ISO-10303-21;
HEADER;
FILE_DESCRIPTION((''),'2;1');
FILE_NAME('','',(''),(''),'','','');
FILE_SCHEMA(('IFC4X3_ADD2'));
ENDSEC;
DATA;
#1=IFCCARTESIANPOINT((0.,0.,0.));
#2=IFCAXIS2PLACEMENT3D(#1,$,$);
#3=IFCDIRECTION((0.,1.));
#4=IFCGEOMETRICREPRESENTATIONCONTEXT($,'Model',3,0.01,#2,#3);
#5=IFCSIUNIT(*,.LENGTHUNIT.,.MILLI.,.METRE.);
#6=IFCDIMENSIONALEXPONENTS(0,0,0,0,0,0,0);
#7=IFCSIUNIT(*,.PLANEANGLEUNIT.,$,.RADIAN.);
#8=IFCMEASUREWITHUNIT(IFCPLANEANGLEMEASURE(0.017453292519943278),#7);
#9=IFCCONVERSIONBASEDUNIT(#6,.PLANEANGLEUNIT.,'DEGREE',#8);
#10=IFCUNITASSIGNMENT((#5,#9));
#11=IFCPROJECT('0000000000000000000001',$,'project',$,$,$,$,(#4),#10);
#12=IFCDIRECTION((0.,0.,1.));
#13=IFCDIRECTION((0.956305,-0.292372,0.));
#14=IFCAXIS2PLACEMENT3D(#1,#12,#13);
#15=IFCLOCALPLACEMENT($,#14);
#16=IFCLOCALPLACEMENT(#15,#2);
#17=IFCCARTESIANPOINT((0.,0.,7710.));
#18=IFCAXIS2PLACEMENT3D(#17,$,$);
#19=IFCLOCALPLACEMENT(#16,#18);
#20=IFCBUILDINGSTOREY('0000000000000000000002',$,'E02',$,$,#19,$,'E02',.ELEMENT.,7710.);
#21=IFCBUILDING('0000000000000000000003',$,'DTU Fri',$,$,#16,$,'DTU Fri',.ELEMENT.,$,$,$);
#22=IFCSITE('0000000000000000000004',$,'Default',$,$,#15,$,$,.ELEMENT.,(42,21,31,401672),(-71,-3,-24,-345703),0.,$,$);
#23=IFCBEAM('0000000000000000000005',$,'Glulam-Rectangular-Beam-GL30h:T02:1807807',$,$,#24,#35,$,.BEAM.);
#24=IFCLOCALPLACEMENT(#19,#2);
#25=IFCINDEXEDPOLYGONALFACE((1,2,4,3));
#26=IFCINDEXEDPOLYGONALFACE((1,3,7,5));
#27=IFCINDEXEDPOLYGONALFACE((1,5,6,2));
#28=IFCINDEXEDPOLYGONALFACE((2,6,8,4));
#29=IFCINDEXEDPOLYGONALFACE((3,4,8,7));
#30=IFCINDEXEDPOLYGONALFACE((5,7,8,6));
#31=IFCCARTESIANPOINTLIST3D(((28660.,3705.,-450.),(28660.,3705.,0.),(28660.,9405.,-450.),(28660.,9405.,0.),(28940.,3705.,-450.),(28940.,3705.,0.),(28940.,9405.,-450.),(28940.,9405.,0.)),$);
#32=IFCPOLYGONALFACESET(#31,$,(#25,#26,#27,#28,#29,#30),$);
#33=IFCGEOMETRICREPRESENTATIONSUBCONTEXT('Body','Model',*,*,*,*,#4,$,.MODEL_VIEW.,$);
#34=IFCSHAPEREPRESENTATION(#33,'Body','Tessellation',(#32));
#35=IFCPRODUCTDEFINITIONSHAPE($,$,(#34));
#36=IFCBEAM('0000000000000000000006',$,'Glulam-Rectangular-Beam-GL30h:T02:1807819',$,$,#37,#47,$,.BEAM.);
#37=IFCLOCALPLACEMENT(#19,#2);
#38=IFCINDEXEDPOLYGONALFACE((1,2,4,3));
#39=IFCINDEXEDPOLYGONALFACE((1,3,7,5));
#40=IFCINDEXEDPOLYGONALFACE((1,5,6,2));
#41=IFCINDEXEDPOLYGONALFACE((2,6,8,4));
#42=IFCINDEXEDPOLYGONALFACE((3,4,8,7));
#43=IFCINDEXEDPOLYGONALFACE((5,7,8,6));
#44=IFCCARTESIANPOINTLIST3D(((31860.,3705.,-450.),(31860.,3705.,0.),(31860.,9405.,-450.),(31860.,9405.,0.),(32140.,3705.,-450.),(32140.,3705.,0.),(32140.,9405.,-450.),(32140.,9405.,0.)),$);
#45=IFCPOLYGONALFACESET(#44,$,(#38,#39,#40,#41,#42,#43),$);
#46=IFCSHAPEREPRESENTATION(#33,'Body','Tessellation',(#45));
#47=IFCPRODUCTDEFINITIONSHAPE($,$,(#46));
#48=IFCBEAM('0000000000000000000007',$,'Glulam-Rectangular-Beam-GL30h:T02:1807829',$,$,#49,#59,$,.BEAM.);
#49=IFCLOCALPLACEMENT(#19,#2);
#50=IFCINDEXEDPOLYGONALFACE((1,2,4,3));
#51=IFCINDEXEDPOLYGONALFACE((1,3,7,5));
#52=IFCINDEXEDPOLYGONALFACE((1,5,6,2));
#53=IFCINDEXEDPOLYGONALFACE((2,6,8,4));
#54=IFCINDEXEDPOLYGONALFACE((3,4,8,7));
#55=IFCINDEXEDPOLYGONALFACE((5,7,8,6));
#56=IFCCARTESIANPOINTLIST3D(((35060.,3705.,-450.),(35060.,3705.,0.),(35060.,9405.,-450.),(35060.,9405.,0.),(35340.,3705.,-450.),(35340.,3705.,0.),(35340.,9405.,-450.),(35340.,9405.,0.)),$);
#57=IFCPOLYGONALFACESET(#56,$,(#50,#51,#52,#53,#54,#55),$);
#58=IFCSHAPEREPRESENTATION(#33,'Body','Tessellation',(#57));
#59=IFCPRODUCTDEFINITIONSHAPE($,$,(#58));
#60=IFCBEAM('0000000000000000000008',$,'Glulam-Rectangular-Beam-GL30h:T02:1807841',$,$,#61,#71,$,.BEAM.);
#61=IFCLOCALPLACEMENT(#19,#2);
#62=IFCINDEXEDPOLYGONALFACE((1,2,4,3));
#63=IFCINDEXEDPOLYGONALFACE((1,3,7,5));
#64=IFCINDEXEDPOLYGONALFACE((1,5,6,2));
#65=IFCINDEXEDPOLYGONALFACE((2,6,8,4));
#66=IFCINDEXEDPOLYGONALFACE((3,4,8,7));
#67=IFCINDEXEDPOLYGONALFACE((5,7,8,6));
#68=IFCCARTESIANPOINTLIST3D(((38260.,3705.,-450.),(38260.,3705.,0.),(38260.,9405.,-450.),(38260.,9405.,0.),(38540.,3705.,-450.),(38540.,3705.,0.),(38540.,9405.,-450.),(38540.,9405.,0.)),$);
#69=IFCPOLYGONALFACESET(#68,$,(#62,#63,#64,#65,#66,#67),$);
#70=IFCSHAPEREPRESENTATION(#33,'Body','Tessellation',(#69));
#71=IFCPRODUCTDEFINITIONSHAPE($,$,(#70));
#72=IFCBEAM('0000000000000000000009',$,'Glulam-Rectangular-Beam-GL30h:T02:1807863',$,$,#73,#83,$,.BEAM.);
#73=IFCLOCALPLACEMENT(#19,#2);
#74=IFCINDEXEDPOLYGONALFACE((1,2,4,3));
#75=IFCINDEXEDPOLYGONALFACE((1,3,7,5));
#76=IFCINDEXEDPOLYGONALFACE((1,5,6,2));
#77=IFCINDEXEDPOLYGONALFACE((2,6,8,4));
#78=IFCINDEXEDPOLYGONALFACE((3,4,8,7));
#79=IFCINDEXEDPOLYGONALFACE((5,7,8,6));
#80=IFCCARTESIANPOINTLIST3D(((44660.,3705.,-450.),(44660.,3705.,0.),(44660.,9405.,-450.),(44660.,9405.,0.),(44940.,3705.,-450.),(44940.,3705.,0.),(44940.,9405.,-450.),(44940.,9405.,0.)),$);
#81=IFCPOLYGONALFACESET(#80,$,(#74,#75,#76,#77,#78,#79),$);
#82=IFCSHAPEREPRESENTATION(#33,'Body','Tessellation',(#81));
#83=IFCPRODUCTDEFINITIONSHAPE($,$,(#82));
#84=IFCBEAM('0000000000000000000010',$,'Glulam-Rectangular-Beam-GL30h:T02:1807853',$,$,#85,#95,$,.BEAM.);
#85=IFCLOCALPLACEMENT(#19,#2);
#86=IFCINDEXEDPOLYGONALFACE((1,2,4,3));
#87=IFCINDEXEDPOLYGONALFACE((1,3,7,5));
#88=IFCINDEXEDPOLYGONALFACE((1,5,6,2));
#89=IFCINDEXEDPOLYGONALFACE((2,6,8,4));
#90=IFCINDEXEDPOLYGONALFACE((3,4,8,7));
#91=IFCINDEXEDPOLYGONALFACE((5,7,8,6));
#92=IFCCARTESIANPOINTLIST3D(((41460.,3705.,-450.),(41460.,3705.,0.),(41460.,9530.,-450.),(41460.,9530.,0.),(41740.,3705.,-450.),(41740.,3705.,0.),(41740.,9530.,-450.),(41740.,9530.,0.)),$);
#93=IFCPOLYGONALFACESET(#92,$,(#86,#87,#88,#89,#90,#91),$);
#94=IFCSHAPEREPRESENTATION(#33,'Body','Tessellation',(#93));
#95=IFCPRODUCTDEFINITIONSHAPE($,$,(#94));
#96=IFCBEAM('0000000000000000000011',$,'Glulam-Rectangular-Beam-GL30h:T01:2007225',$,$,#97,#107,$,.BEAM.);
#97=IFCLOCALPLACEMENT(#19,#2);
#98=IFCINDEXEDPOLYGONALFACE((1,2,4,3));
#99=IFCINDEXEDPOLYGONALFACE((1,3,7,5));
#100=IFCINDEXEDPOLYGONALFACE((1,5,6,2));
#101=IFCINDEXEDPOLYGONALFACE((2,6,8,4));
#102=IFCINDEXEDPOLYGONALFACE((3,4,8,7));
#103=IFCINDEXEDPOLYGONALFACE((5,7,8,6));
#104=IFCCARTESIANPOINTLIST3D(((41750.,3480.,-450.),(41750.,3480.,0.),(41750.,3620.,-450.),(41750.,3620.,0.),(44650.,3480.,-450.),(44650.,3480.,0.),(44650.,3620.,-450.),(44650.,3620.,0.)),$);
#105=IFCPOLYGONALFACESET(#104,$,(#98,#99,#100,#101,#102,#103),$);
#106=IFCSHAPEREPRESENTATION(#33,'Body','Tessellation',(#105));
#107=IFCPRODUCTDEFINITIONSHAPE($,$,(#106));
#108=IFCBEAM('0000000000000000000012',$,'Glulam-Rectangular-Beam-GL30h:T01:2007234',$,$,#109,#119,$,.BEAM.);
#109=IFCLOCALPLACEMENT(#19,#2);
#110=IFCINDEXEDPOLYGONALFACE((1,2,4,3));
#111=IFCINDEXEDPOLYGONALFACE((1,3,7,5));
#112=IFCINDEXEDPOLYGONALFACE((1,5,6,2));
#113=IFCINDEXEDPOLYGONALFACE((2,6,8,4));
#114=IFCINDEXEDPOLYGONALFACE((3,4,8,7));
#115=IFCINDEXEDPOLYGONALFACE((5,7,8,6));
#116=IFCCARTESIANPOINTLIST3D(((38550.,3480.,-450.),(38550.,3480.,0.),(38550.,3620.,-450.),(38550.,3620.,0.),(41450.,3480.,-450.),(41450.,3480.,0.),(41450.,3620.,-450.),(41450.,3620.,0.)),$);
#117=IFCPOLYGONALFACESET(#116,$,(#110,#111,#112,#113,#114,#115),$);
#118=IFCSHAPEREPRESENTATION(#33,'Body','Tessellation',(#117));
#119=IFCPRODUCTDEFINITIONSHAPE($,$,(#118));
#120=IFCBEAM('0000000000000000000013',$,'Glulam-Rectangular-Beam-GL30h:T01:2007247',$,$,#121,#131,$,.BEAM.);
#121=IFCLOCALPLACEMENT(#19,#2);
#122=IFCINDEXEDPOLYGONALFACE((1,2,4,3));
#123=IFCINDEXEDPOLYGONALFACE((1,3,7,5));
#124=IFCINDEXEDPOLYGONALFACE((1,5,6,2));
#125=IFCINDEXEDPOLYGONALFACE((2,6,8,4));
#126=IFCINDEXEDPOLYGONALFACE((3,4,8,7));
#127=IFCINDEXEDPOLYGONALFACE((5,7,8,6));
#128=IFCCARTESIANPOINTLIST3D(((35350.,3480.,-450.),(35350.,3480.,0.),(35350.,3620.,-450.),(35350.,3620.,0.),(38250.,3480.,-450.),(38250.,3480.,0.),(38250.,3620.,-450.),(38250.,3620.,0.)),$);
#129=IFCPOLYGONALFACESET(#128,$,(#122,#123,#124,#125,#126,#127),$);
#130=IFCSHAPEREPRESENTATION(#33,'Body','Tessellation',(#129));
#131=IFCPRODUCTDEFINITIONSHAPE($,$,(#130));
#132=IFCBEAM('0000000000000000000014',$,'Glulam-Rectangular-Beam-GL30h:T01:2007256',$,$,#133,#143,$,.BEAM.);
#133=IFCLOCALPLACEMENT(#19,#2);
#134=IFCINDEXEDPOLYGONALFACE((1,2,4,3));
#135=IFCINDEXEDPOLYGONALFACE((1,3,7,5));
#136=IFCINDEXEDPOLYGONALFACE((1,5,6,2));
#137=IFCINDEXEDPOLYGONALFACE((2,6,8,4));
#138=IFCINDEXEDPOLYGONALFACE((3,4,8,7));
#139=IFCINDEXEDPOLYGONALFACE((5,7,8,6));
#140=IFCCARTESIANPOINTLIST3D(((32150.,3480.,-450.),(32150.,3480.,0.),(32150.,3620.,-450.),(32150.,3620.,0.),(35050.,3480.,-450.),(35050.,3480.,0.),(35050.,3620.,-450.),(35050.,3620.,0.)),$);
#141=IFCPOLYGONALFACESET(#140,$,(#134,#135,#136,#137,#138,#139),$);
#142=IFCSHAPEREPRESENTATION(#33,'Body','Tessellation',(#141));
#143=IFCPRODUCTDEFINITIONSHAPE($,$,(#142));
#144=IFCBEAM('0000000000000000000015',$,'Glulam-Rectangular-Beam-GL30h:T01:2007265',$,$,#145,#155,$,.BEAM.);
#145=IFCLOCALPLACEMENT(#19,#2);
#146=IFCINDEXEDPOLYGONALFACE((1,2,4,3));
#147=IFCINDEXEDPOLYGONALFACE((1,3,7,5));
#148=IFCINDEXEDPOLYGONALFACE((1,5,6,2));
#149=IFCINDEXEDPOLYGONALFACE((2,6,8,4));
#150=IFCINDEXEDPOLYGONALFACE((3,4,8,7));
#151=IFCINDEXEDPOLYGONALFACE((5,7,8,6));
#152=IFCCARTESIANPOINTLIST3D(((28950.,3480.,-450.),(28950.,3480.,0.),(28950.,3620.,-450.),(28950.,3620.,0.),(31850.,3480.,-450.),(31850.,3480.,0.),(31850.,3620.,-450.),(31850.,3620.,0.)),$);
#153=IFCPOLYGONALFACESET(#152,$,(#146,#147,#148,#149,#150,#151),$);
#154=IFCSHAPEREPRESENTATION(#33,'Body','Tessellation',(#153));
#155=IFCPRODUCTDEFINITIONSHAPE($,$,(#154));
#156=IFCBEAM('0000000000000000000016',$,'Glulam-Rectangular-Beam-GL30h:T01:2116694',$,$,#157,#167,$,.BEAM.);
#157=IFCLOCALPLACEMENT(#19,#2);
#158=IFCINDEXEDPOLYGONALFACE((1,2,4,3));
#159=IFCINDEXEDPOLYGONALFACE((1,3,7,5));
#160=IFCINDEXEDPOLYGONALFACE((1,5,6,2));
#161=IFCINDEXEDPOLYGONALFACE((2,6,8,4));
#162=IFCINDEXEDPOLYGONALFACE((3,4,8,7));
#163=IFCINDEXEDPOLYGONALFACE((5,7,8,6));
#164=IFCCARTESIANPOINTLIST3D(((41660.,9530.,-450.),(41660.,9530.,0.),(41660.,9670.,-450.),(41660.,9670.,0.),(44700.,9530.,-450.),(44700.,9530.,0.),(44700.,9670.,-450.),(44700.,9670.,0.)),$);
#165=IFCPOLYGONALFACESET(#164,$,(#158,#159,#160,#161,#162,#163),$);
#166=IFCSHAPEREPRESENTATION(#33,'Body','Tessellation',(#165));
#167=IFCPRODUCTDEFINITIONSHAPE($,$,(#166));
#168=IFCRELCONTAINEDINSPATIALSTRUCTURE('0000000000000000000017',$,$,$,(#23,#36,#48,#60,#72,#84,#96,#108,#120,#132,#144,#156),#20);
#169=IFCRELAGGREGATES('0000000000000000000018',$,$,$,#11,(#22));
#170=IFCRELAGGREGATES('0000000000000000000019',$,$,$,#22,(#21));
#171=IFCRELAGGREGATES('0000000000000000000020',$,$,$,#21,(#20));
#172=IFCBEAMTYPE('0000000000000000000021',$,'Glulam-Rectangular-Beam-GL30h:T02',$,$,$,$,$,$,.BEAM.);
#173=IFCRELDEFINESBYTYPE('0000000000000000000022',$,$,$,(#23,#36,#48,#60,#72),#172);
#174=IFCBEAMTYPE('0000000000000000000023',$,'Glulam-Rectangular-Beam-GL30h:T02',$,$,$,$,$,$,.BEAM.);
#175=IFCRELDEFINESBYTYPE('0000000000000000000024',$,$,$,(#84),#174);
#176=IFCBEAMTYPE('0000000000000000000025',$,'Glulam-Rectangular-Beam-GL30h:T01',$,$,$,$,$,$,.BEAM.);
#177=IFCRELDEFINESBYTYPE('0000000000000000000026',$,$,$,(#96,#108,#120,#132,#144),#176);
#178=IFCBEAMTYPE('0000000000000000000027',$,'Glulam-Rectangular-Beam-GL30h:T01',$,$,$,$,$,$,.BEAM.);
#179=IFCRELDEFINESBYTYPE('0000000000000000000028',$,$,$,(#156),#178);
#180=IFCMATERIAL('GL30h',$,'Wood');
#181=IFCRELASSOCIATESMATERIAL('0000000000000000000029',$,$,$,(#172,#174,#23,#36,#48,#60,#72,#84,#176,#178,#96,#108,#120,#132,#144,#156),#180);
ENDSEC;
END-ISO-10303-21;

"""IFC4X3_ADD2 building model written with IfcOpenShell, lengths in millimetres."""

from ifc_helpers import new_model, entity, si_unit, converted_unit, direction, frame, origin, origin_2d_with_axis, place, context, subcontext, project, spatial, rectangle, extrude, source, transform, mapped, material, material_profile, profile_set, profile_usage, type_object, type_shapes, element, save


model = new_model("IFC4X3_ADD2")

# Units and contexts
model_context = context("Model", 3, precision=0.01, world=origin(), true_north=direction((0.0, 1.0)))
body_context = subcontext(model_context, "Body", "Model", "MODEL_VIEW")
ifc_project = project(units=[si_unit("LENGTHUNIT", "METRE", prefix="MILLI"), converted_unit("PLANEANGLEUNIT", "DEGREE", entity("IfcPlaneAngleMeasure", 0.017453292519943278), si_unit("PLANEANGLEUNIT", "RADIAN"), dimensions=[0, 0, 0, 0, 0, 0, 0])], contexts=[model_context])

# Site, building, storey
site_placement = place(None, frame((0.0, 0.0, 0.0), z_axis=(0.0, 0.0, 1.0), x_axis=(0.956305, -0.292372, 0.0)))
site = spatial("IfcSite", under=ifc_project, at=site_placement, Name="Default", CompositionType="ELEMENT", RefLatitude=(42, 21, 31, 401672), RefLongitude=(-71, -3, -24, -345703), RefElevation=0.0)
building_placement = place(site_placement, origin())
building = spatial("IfcBuilding", under=site, at=building_placement, Name="DTU Fri", LongName="DTU Fri", CompositionType="ELEMENT")
storey_placement = place(building_placement, frame((0.0, 0.0, 7710.0)))
storey = spatial("IfcBuildingStorey", under=building, at=storey_placement, Name="E02", LongName="E02", CompositionType="ELEMENT", Elevation=7710.0)

# Shared definitions
ifc_material = material(Name="GL30h", Category="Wood")

# Beams
ifc_material_profile_1 = material_profile(ifc_material, rectangle(XDim=450.0, YDim=140.0, at=origin_2d_with_axis()), Name="T01")
ifc_profile_set_1 = profile_set([ifc_material_profile_1], Name="T01")
ifc_profile_usage_1 = profile_usage(ifc_profile_set_1, cardinal=8)
ifc_material_profile_2 = material_profile(ifc_material, rectangle(XDim=450.0, YDim=280.0, at=origin_2d_with_axis()), Name="T02")
ifc_profile_set_2 = profile_set([ifc_material_profile_2], Name="T02")
ifc_profile_usage_2 = profile_usage(ifc_profile_set_2, cardinal=8)
beam_type_1 = type_object("IfcBeamType", Name="Glulam-Rectangular-Beam-GL30h:T02", PredefinedType="BEAM", material=ifc_profile_set_2)
shared_shape_1 = source(origin(), body_context, "Body", "SweptSolid", [
    extrude(rectangle(XDim=450.0, YDim=280.0, at=origin_2d_with_axis()), frame((-2872.5, 0.0, 0.0), z_axis=(1.0, 0.0, 0.0), x_axis=(0.0, 0.0, -1.0)), (0.0, 0.0, 1.0), 5700.0),
])
type_shapes(beam_type_1, [shared_shape_1])
for number, where, z_axis, x_axis, name in (
    (1, (28800.0, 6577.5, -225.0), (0.0, 0.0, 1.0), (0.0, 1.0, 0.0), "Glulam-Rectangular-Beam-GL30h:T02:1807807"),
    (2, (32000.0, 6577.5, -225.0), (0.0, 0.0, 1.0), (0.0, 1.0, 0.0), "Glulam-Rectangular-Beam-GL30h:T02:1807819"),
    (3, (35200.0, 6577.5, -225.0), (0.0, 0.0, 1.0), (0.0, 1.0, 0.0), "Glulam-Rectangular-Beam-GL30h:T02:1807829"),
    (4, (38400.0, 6577.5, -225.0), (0.0, 0.0, 1.0), (0.0, 1.0, 0.0), "Glulam-Rectangular-Beam-GL30h:T02:1807841"),
    (5, (44800.0, 6577.5, -225.0), (0.0, 0.0, 1.0), (0.0, 1.0, 0.0), "Glulam-Rectangular-Beam-GL30h:T02:1807863"),
):
    element("IfcBeam", number, at=place(storey_placement, frame(where, z_axis=z_axis, x_axis=x_axis)), inside=storey, type_object=beam_type_1, material=ifc_profile_usage_2, Name=name, PredefinedType="BEAM", context=body_context, shape_type="MappedRepresentation", body=[
        mapped(shared_shape_1, transform((0.0, 0.0, 0.0), scale=1.0)),
    ])
beam_type_2 = type_object("IfcBeamType", Name="Glulam-Rectangular-Beam-GL30h:T02", PredefinedType="BEAM", material=ifc_profile_set_2)
shared_shape_2 = source(origin(), body_context, "Body", "SweptSolid", [
    extrude(rectangle(XDim=450.0, YDim=280.0, at=origin_2d_with_axis()), frame((-2872.5, 0.0, 0.0), z_axis=(1.0, 0.0, 0.0), x_axis=(0.0, 0.0, -1.0)), (0.0, 0.0, 1.0), 5825.0),
])
type_shapes(beam_type_2, [shared_shape_2])
beam_1_placement = place(storey_placement, frame((41600.0, 6577.5, -225.0), z_axis=(0.0, 0.0, 1.0), x_axis=(0.0, 1.0, 0.0)))
element("IfcBeam", 6, at=beam_1_placement, inside=storey, type_object=beam_type_2, material=ifc_profile_usage_2, Name="Glulam-Rectangular-Beam-GL30h:T02:1807853", PredefinedType="BEAM", context=body_context, shape_type="MappedRepresentation", body=[
    mapped(shared_shape_2, transform((0.0, 0.0, 0.0), scale=1.0)),
])
beam_type_3 = type_object("IfcBeamType", Name="Glulam-Rectangular-Beam-GL30h:T01", PredefinedType="BEAM", material=ifc_profile_set_1)
shared_shape_3 = source(origin(), body_context, "Body", "SweptSolid", [
    extrude(rectangle(XDim=450.0, YDim=140.0, at=origin_2d_with_axis()), frame((-1460.0, 0.0, 0.0), z_axis=(1.0, 0.0, 0.0), x_axis=(0.0, 0.0, -1.0)), (0.0, 0.0, 1.0), 2900.0),
])
type_shapes(beam_type_3, [shared_shape_3])
for number, where, name in (
    (7, (43210.0, 3550.0, -225.0), "Glulam-Rectangular-Beam-GL30h:T01:2007225"),
    (8, (40010.0, 3550.0, -225.0), "Glulam-Rectangular-Beam-GL30h:T01:2007234"),
    (9, (36810.0, 3550.0, -225.0), "Glulam-Rectangular-Beam-GL30h:T01:2007247"),
    (10, (33610.0, 3550.0, -225.0), "Glulam-Rectangular-Beam-GL30h:T01:2007256"),
    (11, (30410.0, 3550.0, -225.0), "Glulam-Rectangular-Beam-GL30h:T01:2007265"),
):
    element("IfcBeam", number, at=place(storey_placement, frame(where)), inside=storey, type_object=beam_type_3, material=ifc_profile_usage_1, Name=name, PredefinedType="BEAM", context=body_context, shape_type="MappedRepresentation", body=[
        mapped(shared_shape_3, transform((0.0, 0.0, 0.0), scale=1.0)),
    ])
beam_type_4 = type_object("IfcBeamType", Name="Glulam-Rectangular-Beam-GL30h:T01", PredefinedType="BEAM", material=ifc_profile_set_1)
shared_shape_4 = source(origin(), body_context, "Body", "SweptSolid", [
    extrude(rectangle(XDim=450.0, YDim=140.0, at=origin_2d_with_axis()), frame((-1540.0, 0.0, 0.0), z_axis=(1.0, 0.0, 0.0), x_axis=(0.0, 0.0, -1.0)), (0.0, 0.0, 1.0), 3040.0),
])
type_shapes(beam_type_4, [shared_shape_4])
beam_2_placement = place(storey_placement, frame((43200.0, 9600.0, -225.0)))
element("IfcBeam", 12, at=beam_2_placement, inside=storey, type_object=beam_type_4, material=ifc_profile_usage_1, Name="Glulam-Rectangular-Beam-GL30h:T01:2116694", PredefinedType="BEAM", context=body_context, shape_type="MappedRepresentation", body=[
    mapped(shared_shape_4, transform((0.0, 0.0, 0.0), scale=1.0)),
])

save(model, "model.ifc")
